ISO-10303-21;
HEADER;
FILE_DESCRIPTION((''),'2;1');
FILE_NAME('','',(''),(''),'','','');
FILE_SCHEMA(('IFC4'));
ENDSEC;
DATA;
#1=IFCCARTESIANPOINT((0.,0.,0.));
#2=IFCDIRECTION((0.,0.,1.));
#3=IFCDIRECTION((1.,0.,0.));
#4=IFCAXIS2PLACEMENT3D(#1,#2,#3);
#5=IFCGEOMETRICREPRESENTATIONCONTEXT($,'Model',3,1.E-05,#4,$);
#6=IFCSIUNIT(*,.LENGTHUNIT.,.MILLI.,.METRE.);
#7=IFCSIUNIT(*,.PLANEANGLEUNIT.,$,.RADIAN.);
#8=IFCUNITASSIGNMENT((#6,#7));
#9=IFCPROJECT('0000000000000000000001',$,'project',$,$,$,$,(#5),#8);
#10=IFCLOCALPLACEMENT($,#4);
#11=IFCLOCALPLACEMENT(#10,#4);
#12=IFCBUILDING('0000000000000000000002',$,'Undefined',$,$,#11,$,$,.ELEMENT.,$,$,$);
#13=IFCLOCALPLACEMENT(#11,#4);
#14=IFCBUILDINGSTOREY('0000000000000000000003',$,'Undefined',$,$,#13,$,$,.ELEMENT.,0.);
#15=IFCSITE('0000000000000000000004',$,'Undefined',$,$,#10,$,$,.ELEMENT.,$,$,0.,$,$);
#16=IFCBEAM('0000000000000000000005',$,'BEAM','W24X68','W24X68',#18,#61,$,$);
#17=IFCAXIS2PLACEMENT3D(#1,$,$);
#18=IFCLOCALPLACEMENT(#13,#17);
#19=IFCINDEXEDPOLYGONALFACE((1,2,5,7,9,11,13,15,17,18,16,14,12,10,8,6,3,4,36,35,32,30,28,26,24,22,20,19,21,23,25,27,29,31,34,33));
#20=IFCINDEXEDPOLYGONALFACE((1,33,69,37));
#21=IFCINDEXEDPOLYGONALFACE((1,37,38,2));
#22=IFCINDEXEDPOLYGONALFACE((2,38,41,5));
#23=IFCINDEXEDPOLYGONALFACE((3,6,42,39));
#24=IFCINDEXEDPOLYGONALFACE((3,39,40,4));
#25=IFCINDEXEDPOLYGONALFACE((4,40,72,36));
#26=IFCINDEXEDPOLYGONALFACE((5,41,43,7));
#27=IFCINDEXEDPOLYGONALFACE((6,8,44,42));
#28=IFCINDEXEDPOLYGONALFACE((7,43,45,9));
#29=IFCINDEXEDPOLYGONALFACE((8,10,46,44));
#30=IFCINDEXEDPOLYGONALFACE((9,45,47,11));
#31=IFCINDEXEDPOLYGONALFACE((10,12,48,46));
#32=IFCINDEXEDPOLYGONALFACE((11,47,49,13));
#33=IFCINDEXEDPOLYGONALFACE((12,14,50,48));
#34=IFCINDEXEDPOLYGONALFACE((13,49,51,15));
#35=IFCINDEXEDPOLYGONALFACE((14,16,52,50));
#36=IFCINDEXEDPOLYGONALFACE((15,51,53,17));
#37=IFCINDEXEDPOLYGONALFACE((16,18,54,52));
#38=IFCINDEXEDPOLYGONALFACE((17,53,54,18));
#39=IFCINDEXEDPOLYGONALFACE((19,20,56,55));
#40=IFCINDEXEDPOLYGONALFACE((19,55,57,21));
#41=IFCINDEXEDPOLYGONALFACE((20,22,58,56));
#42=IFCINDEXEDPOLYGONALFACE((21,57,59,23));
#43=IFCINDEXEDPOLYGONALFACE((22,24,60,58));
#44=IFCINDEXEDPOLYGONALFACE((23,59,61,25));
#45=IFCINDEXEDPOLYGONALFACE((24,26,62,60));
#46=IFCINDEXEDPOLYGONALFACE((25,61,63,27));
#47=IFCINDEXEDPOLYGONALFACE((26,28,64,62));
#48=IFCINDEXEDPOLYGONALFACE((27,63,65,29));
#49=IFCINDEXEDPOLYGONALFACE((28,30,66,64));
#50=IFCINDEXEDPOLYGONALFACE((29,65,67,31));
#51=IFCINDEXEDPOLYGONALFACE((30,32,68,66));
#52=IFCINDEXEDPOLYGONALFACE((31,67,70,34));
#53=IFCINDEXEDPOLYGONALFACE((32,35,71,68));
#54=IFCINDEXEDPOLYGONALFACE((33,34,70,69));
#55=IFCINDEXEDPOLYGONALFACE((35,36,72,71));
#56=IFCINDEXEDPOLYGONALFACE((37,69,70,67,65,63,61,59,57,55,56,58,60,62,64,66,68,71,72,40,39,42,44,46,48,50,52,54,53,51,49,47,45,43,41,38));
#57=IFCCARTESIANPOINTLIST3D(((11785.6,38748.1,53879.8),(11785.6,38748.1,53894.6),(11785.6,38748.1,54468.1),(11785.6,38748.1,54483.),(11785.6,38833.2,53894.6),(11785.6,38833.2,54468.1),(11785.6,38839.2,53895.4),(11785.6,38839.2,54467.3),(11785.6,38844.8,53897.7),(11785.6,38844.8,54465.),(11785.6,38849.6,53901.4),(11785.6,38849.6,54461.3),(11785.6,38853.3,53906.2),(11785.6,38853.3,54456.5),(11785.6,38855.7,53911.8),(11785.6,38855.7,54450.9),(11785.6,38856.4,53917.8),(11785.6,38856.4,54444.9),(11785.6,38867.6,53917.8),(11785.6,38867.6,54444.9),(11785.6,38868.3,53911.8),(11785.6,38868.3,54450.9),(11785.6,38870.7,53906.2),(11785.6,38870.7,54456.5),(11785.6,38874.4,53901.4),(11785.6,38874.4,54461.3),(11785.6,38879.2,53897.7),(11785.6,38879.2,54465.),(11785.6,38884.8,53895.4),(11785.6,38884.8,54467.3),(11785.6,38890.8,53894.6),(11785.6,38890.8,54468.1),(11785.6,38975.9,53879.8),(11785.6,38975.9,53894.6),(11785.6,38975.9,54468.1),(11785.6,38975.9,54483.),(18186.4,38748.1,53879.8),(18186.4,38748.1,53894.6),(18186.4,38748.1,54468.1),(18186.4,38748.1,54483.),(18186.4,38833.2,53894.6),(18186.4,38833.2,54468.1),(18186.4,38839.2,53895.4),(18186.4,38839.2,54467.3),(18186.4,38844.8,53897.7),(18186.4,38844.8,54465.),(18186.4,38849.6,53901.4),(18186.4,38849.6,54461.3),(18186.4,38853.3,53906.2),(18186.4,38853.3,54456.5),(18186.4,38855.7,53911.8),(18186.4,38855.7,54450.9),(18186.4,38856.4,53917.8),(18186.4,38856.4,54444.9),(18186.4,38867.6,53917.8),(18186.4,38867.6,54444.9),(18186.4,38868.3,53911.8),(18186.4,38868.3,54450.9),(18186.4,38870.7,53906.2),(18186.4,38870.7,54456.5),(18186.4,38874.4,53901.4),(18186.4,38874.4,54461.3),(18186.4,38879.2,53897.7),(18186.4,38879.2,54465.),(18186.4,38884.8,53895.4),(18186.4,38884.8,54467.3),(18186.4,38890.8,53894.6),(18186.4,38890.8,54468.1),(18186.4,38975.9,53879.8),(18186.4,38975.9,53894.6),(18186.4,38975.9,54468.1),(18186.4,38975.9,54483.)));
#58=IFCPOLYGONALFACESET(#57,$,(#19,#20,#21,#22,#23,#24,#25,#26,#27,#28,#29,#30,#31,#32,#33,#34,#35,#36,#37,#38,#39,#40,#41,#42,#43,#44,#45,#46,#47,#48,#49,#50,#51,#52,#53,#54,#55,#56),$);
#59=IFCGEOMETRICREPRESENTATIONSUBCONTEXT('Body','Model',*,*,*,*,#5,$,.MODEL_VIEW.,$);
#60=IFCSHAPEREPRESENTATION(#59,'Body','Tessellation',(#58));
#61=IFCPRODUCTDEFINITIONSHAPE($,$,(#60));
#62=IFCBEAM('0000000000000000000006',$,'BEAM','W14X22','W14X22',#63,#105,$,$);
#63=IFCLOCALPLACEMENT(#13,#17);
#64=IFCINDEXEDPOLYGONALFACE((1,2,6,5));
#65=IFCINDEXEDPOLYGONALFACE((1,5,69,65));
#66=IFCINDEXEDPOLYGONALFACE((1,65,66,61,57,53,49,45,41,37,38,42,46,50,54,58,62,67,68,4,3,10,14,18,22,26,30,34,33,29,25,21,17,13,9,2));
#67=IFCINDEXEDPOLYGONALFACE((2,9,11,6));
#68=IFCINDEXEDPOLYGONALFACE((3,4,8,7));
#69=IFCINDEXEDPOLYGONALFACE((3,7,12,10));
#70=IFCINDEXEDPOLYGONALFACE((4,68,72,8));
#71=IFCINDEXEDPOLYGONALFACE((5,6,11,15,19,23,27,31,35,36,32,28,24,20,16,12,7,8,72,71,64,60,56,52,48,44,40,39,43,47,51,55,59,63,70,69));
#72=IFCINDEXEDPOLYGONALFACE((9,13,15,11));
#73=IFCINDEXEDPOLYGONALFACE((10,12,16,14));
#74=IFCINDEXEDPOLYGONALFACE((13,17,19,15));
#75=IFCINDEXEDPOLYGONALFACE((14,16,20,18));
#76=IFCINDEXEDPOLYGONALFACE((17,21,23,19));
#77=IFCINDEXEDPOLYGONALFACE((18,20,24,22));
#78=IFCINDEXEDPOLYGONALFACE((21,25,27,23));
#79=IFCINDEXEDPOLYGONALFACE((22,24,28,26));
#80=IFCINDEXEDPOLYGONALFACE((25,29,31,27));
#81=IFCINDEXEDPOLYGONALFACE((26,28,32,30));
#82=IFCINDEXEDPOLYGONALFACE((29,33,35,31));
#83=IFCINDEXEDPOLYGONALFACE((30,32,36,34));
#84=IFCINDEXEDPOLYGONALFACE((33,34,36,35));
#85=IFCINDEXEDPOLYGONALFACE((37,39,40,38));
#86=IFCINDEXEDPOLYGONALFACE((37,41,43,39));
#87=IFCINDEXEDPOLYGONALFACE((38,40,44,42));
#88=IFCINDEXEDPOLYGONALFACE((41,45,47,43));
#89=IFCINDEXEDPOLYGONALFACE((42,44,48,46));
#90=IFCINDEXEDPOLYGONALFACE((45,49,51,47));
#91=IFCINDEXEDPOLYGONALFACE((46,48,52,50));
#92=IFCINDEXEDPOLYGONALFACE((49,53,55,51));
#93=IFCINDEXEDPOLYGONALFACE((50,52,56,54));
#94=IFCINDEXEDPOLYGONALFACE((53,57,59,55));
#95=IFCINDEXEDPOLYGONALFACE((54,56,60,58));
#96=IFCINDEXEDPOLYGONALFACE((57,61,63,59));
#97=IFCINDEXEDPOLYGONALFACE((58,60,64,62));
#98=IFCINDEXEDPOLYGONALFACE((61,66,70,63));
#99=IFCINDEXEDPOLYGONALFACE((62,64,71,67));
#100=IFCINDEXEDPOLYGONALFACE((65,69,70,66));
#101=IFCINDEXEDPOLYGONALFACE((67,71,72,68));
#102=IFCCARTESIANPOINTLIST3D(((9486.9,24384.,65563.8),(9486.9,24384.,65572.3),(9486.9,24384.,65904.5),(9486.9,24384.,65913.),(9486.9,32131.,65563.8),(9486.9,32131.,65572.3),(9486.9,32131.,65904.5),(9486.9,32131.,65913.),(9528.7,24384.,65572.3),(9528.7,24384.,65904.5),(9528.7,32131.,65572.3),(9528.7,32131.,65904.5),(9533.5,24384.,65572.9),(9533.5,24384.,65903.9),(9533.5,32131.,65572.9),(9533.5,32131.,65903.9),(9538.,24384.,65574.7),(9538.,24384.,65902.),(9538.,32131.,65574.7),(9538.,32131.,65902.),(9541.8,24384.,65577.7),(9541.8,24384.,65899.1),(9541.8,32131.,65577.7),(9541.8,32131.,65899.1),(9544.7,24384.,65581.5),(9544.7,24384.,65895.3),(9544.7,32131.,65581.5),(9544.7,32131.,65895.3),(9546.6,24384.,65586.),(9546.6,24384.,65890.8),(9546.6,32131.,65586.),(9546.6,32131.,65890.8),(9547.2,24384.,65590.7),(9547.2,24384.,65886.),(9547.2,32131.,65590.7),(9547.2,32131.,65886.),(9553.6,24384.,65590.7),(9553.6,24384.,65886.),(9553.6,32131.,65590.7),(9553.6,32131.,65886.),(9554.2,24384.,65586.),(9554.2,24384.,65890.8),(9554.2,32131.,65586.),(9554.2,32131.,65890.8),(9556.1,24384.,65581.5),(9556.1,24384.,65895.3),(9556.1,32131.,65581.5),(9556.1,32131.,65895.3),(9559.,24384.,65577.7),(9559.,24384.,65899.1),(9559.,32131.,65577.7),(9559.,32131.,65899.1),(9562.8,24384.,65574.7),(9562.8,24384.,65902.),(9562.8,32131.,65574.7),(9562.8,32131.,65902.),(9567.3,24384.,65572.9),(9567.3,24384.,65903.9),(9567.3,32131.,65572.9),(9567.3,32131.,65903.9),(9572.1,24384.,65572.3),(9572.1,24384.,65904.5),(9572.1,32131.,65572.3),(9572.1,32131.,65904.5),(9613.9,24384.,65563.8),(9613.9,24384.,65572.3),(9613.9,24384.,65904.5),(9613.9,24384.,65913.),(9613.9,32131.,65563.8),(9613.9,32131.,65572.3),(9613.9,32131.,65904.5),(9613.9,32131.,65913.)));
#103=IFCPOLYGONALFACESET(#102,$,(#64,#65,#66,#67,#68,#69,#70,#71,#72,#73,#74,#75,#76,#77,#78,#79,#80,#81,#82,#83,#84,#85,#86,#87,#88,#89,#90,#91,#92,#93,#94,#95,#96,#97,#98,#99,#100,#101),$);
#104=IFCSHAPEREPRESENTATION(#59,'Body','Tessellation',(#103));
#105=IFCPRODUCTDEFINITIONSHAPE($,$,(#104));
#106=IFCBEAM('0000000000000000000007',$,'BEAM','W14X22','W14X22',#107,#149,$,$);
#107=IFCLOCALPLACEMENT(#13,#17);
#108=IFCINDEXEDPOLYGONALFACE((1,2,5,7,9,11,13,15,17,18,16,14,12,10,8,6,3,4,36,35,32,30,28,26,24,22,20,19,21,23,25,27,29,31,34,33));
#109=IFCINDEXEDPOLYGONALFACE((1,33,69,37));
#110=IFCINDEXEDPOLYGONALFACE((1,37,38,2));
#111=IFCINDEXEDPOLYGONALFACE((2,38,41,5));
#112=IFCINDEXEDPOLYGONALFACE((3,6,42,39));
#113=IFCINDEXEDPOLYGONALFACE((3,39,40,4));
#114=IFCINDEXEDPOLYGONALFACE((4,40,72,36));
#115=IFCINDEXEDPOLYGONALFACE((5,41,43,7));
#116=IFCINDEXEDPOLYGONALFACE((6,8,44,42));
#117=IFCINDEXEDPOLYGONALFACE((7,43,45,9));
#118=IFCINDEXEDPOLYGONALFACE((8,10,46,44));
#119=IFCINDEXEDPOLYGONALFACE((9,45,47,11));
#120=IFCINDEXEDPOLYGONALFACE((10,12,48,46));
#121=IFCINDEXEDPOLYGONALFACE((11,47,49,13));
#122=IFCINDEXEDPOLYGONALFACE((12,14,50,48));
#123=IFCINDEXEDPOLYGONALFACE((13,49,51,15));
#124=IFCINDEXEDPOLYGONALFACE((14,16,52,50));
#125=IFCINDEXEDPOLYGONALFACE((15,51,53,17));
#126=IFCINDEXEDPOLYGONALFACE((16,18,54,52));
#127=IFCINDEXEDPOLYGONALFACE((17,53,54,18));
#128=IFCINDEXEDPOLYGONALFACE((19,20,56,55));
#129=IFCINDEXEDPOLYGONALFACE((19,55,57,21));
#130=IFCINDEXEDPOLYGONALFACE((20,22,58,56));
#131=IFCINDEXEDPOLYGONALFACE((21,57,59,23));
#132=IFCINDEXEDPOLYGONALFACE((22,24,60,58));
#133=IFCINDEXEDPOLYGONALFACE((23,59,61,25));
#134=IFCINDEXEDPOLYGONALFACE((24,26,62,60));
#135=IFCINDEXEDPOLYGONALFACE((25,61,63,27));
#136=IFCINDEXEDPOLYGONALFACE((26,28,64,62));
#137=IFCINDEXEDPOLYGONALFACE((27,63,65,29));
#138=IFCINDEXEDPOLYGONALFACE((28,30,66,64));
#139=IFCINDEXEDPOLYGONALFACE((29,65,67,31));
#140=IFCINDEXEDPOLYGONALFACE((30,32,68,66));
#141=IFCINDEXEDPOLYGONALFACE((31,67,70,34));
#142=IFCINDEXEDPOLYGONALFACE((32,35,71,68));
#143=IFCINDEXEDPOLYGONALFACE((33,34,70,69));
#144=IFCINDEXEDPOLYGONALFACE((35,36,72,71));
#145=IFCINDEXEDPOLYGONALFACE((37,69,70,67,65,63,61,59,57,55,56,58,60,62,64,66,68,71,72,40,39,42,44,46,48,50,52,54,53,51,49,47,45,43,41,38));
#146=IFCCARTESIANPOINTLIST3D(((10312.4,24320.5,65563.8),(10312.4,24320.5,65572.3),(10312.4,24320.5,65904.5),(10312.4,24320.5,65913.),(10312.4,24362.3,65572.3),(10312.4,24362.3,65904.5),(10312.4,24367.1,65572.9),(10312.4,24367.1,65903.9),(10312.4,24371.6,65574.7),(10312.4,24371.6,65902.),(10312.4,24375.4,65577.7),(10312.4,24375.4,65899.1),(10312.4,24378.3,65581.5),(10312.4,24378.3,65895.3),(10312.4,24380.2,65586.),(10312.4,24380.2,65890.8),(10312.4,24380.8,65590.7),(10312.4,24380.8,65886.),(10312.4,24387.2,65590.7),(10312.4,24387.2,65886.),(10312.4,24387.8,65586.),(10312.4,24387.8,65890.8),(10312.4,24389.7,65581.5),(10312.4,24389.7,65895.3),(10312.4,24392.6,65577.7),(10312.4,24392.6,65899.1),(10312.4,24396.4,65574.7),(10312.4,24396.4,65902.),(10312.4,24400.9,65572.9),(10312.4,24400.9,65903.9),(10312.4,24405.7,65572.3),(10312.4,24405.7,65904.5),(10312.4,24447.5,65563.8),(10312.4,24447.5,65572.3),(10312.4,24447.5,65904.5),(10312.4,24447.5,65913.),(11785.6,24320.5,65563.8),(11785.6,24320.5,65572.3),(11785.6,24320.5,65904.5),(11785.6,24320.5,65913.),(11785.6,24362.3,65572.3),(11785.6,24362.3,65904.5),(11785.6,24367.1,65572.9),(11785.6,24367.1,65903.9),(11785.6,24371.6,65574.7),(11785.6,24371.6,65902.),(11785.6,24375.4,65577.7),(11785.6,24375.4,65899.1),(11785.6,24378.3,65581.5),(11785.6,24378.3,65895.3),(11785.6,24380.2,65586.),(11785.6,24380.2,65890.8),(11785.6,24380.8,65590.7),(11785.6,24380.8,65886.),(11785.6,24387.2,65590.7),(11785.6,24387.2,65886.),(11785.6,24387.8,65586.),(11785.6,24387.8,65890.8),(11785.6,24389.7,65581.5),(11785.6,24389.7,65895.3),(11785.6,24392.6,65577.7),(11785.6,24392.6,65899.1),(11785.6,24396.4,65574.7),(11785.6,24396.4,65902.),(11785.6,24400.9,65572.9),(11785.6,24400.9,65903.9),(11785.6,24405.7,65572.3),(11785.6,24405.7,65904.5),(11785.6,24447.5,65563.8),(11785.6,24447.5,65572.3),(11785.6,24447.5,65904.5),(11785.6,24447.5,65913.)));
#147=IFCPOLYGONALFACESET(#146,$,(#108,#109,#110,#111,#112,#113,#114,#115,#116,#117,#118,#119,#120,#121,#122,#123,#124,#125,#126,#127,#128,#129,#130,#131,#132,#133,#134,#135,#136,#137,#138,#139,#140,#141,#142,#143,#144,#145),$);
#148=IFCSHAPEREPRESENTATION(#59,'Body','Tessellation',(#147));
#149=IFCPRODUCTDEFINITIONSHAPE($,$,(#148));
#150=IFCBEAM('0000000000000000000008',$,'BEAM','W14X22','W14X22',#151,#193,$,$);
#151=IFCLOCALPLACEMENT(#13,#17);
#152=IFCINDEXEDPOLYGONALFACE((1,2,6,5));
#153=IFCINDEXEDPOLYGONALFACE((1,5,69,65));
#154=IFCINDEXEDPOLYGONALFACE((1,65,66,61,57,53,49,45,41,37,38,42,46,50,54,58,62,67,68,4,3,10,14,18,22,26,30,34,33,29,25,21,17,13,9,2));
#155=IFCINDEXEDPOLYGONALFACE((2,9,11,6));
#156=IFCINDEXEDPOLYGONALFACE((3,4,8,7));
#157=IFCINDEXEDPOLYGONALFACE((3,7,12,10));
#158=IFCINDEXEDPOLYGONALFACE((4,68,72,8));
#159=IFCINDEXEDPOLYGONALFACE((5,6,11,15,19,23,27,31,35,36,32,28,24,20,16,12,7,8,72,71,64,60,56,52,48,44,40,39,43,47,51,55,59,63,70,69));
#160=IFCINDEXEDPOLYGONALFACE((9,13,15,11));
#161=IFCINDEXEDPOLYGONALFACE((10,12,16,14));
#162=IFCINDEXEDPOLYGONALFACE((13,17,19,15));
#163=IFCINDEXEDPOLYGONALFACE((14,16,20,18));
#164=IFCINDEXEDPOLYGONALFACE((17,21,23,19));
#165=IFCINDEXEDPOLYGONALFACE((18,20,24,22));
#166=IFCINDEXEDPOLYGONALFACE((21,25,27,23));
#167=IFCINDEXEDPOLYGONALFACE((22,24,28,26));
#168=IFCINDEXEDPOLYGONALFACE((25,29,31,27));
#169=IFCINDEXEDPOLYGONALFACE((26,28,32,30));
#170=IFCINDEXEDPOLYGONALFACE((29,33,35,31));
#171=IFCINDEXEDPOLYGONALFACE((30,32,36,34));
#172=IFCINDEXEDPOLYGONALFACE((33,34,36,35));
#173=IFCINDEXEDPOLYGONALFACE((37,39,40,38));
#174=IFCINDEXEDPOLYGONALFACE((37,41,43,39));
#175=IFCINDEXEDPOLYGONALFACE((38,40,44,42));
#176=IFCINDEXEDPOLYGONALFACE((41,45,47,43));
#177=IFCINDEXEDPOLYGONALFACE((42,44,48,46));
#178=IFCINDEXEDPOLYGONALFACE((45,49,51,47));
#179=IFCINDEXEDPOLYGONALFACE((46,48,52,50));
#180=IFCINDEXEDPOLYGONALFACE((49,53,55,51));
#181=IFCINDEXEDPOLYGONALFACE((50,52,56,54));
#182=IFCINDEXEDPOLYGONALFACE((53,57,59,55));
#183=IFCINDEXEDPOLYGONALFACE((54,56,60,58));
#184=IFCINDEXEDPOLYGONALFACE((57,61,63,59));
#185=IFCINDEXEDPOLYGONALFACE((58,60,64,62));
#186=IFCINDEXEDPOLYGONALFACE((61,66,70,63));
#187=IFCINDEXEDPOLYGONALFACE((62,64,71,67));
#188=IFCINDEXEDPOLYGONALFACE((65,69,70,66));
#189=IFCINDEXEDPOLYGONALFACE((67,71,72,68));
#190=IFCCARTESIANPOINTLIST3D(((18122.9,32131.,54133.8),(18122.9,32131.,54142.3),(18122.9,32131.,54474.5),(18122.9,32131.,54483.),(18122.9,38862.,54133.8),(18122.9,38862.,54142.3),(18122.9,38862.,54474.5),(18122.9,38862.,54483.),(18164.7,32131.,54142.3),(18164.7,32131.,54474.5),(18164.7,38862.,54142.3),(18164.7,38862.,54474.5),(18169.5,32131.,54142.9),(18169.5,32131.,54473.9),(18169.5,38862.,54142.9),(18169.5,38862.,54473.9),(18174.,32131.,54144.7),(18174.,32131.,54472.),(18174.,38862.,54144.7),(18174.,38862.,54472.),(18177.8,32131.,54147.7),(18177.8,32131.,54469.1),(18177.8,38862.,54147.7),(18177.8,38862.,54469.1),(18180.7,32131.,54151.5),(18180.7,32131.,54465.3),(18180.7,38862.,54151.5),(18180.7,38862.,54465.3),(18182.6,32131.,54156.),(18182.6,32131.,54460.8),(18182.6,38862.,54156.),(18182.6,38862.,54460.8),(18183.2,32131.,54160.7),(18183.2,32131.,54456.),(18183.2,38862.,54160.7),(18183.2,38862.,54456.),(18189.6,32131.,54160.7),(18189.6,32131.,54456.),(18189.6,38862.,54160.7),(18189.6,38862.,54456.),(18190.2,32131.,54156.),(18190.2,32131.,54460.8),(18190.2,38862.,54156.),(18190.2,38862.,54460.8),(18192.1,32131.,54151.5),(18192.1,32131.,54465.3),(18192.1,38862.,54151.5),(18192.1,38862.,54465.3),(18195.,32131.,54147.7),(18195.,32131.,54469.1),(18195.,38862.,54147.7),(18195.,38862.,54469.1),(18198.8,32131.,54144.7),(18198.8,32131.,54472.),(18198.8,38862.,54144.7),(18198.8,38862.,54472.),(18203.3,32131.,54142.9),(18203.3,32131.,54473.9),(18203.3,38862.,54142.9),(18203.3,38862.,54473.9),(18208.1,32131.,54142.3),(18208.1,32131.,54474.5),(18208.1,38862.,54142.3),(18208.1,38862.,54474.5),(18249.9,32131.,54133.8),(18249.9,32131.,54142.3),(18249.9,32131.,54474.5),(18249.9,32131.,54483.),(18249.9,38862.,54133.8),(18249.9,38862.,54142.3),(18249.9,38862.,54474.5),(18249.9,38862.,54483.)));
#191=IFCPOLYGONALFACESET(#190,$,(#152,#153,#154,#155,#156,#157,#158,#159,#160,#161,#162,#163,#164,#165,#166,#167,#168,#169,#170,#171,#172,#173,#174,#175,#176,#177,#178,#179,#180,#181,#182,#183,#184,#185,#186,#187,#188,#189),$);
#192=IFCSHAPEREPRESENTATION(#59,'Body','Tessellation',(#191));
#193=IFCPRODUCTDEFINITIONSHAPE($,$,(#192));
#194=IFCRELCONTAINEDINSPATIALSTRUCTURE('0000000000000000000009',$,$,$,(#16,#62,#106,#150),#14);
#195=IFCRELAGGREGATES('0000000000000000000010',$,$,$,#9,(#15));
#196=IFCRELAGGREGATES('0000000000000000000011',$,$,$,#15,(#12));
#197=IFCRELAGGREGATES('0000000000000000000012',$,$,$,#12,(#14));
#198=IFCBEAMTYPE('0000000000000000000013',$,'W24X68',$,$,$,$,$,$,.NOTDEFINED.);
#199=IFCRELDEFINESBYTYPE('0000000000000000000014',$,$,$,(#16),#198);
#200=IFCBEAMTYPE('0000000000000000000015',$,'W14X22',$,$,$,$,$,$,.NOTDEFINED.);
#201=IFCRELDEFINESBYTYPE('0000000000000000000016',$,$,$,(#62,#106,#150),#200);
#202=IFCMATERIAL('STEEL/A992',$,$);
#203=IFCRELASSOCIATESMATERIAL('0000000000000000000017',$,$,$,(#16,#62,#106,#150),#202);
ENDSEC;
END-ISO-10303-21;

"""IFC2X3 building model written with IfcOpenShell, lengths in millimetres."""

from ifc_helpers import new_model, si_unit, frame, origin_with_axes, origin_2d_with_axis, place, context, subcontext, project, spatial, i_section, extrude, material, type_object, element, save


model = new_model("IFC2X3")

# Units and contexts
model_context = context("Model", 3, precision=1e-05, world=origin_with_axes())
body_context = subcontext(model_context, "Body", "Model", "MODEL_VIEW")
ifc_project = project(units=[si_unit("LENGTHUNIT", "METRE", prefix="MILLI"), si_unit("PLANEANGLEUNIT", "RADIAN")], contexts=[model_context])

# Site, building, storey
site_placement = place(None, origin_with_axes())
site = spatial("IfcSite", under=ifc_project, at=site_placement, Name="Undefined", CompositionType="ELEMENT", RefElevation=0.0)
building_placement = place(site_placement, origin_with_axes())
building = spatial("IfcBuilding", under=site, at=building_placement, Name="Undefined", CompositionType="ELEMENT")
storey_placement = place(building_placement, origin_with_axes())
storey = spatial("IfcBuildingStorey", under=building, at=storey_placement, Name="Undefined", CompositionType="ELEMENT", Elevation=0.0)

# Shared definitions
ifc_material_1 = material(Name="STEEL/A992")

# Beams
beam_type_1 = type_object("IfcBeamType", Name="W24X68", PredefinedType="NOTDEFINED")
for number, where, z_axis, x_axis, name in (
    (1, (11785.6, 38862.0, 54181.4), (0.0, 0.0, 1.0), (1.0, 0.0, 0.0), "BEAM"),
):
    element("IfcBeam", number, at=place(storey_placement, frame(where, z_axis=z_axis, x_axis=x_axis)), inside=storey, type_object=beam_type_1, material=ifc_material_1, Name=name, Description="W24X68", ObjectType="W24X68", context=body_context, shape_type="SweptSolid", body=[
        extrude(i_section(OverallWidth=227.8, OverallDepth=603.2, WebThickness=11.1, FlangeThickness=14.9, FilletRadius=23.2, at=origin_2d_with_axis()), frame((6400.8, 0.0, 0.0), z_axis=(-1.0, 0.0, 0.0), x_axis=(0.0, -1.0, 0.0)), (0.0, 0.0, 1.0), 6400.8),
    ])
beam_type_2 = type_object("IfcBeamType", Name="W14X22", PredefinedType="NOTDEFINED")
beam_1_placement = place(storey_placement, frame((9550.4, 24384.0, 65738.4), z_axis=(0.0, 0.0, 1.0), x_axis=(0.0, 1.0, 0.0)))
element("IfcBeam", 2, at=beam_1_placement, inside=storey, type_object=beam_type_2, material=ifc_material_1, Name="BEAM", Description="W14X22", ObjectType="W14X22", context=body_context, shape_type="SweptSolid", body=[
    extrude(i_section(OverallWidth=127.0, OverallDepth=349.2, WebThickness=6.3, FlangeThickness=8.5, FilletRadius=18.5, at=origin_2d_with_axis()), frame((7747.0, 0.0, 0.0), z_axis=(-1.0, 0.0, 0.0), x_axis=(0.0, -1.0, 0.0)), (0.0, 0.0, 1.0), 7747.0),
])
beam_2_placement = place(storey_placement, frame((10312.4, 24384.0, 65738.4), z_axis=(0.0, 0.0, 1.0), x_axis=(1.0, 0.0, 0.0)))
element("IfcBeam", 3, at=beam_2_placement, inside=storey, type_object=beam_type_2, material=ifc_material_1, Name="BEAM", Description="W14X22", ObjectType="W14X22", context=body_context, shape_type="SweptSolid", body=[
    extrude(i_section(OverallWidth=127.0, OverallDepth=349.2, WebThickness=6.3, FlangeThickness=8.5, FilletRadius=18.5, at=origin_2d_with_axis()), frame((1473.2, 0.0, 0.0), z_axis=(-1.0, 0.0, 0.0), x_axis=(0.0, -1.0, 0.0)), (0.0, 0.0, 1.0), 1473.2),
])
for number, where, z_axis, x_axis, name in (
    (4, (18186.4, 32131.0, 54308.4), (0.0, 0.0, 1.0), (0.0, 1.0, 0.0), "BEAM"),
):
    element("IfcBeam", number, at=place(storey_placement, frame(where, z_axis=z_axis, x_axis=x_axis)), inside=storey, type_object=beam_type_2, material=ifc_material_1, Name=name, Description="W14X22", ObjectType="W14X22", context=body_context, shape_type="SweptSolid", body=[
        extrude(i_section(OverallWidth=127.0, OverallDepth=349.2, WebThickness=6.3, FlangeThickness=8.5, FilletRadius=18.5, at=origin_2d_with_axis()), frame((6731.0, 0.0, 0.0), z_axis=(-1.0, 0.0, 0.0), x_axis=(0.0, -1.0, 0.0)), (0.0, 0.0, 1.0), 6731.0),
    ])

save(model, "model.ifc")
